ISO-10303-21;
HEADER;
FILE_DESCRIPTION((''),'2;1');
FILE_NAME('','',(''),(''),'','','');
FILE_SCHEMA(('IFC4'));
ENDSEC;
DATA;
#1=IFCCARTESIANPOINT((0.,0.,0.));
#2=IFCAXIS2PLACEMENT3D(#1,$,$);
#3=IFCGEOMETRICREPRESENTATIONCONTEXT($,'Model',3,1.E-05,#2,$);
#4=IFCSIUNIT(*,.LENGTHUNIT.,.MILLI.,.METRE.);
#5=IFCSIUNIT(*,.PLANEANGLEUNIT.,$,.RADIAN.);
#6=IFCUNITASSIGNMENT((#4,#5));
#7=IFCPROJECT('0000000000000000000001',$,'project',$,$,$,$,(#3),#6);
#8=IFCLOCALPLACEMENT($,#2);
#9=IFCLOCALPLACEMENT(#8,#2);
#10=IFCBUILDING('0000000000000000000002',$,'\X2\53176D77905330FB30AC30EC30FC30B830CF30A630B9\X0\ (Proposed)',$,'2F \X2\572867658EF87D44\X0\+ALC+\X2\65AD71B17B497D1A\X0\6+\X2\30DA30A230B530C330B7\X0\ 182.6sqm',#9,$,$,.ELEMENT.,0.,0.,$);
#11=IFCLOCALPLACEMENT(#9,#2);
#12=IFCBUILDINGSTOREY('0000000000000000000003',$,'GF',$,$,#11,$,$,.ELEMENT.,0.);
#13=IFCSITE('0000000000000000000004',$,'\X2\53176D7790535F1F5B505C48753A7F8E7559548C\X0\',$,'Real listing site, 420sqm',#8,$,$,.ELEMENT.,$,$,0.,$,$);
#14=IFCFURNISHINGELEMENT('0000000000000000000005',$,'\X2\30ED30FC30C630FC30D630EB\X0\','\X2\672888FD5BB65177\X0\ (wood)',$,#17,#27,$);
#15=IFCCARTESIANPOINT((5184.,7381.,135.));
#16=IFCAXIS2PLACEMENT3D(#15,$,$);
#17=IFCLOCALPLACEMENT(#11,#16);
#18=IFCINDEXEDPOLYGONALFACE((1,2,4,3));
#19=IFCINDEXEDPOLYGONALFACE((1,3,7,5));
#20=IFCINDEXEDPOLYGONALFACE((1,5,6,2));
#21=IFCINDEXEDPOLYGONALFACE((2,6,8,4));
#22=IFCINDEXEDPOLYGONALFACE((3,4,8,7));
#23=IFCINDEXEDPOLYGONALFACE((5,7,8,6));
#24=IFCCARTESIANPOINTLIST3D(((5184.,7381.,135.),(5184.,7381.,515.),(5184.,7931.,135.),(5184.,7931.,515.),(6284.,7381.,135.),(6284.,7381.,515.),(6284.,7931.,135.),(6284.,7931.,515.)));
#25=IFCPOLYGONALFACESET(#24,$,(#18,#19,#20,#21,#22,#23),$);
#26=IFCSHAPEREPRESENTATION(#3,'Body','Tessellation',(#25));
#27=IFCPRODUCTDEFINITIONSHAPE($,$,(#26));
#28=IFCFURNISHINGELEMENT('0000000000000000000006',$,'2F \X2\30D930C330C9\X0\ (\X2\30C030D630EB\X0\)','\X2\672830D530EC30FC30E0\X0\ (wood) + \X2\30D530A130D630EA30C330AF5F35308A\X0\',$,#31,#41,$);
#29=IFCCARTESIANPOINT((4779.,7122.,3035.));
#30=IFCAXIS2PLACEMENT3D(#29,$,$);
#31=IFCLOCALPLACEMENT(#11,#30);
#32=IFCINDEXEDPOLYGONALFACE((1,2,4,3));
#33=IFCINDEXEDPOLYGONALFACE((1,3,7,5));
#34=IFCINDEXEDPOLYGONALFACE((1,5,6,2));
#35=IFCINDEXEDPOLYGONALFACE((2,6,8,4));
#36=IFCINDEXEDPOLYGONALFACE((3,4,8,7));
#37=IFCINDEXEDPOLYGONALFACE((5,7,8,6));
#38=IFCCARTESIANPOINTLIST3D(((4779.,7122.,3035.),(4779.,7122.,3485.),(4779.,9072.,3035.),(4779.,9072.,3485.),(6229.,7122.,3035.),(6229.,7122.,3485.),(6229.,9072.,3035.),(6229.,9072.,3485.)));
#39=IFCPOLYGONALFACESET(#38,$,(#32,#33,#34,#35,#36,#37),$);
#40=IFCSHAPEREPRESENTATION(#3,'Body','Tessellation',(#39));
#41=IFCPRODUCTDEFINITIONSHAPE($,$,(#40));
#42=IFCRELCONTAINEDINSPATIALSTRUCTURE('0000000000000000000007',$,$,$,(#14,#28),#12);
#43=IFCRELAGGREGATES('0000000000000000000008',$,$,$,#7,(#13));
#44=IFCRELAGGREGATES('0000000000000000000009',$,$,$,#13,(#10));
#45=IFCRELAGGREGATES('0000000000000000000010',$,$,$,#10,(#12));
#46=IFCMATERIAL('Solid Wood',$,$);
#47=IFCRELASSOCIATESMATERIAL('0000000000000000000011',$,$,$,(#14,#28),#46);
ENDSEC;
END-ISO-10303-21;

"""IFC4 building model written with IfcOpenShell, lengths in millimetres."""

from ifc_helpers import new_model, si_unit, frame, frame_2d, origin, place, context, project, spatial, rectangle, extrude, material, element, save


model = new_model("IFC4")

# Units and contexts
model_context = context("Model", 3, precision=1e-05, world=origin())
ifc_project = project(units=[si_unit("LENGTHUNIT", "METRE", prefix="MILLI"), si_unit("PLANEANGLEUNIT", "RADIAN")], contexts=[model_context])

# Site, building, storey
site_placement = place(None, origin())
site = spatial("IfcSite", under=ifc_project, at=site_placement, Name="北海道弟子屈町美留和", ObjectType="Real listing site, 420sqm", CompositionType="ELEMENT", RefElevation=0.0)
building_placement = place(site_placement, origin())
building = spatial("IfcBuilding", under=site, at=building_placement, Name="北海道・ガレージハウス (Proposed)", ObjectType="2F 在来軸組+ALC+断熱等級6+ペアサッシ 182.6sqm", CompositionType="ELEMENT", ElevationOfRefHeight=0.0, ElevationOfTerrain=0.0)
storey_placement = place(building_placement, origin())
storey = spatial("IfcBuildingStorey", under=building, at=storey_placement, Name="GF", CompositionType="ELEMENT", Elevation=0.0)

# Shared definitions
ifc_material_1 = material(Name="Solid Wood")

# Furnishing elements
furnishing_1_placement = place(storey_placement, frame((5184.0, 7381.0, 135.0)))
element("IfcFurnishingElement", 1, at=furnishing_1_placement, inside=storey, material=ifc_material_1, Name="ローテーブル", Description="木製家具 (wood)", context=model_context, shape_type="SweptSolid", body=[
    extrude(rectangle(XDim=1100.0, YDim=550.0, at=frame_2d((550.0, 275.0))), frame((5184.0, 7381.0, 135.0)), (0.0, 0.0, 1.0), 380.0),
])
furnishing_2_placement = place(storey_placement, frame((4779.0, 7122.0, 3035.0)))
element("IfcFurnishingElement", 2, at=furnishing_2_placement, inside=storey, material=ifc_material_1, Name="2F ベッド (ダブル)", Description="木フレーム (wood) + ファブリック張り", context=model_context, shape_type="SweptSolid", body=[
    extrude(rectangle(XDim=1450.0, YDim=1950.0, at=frame_2d((725.0, 975.0))), frame((4779.0, 7122.0, 3035.0)), (0.0, 0.0, 1.0), 450.0),
])

save(model, "model.ifc")
